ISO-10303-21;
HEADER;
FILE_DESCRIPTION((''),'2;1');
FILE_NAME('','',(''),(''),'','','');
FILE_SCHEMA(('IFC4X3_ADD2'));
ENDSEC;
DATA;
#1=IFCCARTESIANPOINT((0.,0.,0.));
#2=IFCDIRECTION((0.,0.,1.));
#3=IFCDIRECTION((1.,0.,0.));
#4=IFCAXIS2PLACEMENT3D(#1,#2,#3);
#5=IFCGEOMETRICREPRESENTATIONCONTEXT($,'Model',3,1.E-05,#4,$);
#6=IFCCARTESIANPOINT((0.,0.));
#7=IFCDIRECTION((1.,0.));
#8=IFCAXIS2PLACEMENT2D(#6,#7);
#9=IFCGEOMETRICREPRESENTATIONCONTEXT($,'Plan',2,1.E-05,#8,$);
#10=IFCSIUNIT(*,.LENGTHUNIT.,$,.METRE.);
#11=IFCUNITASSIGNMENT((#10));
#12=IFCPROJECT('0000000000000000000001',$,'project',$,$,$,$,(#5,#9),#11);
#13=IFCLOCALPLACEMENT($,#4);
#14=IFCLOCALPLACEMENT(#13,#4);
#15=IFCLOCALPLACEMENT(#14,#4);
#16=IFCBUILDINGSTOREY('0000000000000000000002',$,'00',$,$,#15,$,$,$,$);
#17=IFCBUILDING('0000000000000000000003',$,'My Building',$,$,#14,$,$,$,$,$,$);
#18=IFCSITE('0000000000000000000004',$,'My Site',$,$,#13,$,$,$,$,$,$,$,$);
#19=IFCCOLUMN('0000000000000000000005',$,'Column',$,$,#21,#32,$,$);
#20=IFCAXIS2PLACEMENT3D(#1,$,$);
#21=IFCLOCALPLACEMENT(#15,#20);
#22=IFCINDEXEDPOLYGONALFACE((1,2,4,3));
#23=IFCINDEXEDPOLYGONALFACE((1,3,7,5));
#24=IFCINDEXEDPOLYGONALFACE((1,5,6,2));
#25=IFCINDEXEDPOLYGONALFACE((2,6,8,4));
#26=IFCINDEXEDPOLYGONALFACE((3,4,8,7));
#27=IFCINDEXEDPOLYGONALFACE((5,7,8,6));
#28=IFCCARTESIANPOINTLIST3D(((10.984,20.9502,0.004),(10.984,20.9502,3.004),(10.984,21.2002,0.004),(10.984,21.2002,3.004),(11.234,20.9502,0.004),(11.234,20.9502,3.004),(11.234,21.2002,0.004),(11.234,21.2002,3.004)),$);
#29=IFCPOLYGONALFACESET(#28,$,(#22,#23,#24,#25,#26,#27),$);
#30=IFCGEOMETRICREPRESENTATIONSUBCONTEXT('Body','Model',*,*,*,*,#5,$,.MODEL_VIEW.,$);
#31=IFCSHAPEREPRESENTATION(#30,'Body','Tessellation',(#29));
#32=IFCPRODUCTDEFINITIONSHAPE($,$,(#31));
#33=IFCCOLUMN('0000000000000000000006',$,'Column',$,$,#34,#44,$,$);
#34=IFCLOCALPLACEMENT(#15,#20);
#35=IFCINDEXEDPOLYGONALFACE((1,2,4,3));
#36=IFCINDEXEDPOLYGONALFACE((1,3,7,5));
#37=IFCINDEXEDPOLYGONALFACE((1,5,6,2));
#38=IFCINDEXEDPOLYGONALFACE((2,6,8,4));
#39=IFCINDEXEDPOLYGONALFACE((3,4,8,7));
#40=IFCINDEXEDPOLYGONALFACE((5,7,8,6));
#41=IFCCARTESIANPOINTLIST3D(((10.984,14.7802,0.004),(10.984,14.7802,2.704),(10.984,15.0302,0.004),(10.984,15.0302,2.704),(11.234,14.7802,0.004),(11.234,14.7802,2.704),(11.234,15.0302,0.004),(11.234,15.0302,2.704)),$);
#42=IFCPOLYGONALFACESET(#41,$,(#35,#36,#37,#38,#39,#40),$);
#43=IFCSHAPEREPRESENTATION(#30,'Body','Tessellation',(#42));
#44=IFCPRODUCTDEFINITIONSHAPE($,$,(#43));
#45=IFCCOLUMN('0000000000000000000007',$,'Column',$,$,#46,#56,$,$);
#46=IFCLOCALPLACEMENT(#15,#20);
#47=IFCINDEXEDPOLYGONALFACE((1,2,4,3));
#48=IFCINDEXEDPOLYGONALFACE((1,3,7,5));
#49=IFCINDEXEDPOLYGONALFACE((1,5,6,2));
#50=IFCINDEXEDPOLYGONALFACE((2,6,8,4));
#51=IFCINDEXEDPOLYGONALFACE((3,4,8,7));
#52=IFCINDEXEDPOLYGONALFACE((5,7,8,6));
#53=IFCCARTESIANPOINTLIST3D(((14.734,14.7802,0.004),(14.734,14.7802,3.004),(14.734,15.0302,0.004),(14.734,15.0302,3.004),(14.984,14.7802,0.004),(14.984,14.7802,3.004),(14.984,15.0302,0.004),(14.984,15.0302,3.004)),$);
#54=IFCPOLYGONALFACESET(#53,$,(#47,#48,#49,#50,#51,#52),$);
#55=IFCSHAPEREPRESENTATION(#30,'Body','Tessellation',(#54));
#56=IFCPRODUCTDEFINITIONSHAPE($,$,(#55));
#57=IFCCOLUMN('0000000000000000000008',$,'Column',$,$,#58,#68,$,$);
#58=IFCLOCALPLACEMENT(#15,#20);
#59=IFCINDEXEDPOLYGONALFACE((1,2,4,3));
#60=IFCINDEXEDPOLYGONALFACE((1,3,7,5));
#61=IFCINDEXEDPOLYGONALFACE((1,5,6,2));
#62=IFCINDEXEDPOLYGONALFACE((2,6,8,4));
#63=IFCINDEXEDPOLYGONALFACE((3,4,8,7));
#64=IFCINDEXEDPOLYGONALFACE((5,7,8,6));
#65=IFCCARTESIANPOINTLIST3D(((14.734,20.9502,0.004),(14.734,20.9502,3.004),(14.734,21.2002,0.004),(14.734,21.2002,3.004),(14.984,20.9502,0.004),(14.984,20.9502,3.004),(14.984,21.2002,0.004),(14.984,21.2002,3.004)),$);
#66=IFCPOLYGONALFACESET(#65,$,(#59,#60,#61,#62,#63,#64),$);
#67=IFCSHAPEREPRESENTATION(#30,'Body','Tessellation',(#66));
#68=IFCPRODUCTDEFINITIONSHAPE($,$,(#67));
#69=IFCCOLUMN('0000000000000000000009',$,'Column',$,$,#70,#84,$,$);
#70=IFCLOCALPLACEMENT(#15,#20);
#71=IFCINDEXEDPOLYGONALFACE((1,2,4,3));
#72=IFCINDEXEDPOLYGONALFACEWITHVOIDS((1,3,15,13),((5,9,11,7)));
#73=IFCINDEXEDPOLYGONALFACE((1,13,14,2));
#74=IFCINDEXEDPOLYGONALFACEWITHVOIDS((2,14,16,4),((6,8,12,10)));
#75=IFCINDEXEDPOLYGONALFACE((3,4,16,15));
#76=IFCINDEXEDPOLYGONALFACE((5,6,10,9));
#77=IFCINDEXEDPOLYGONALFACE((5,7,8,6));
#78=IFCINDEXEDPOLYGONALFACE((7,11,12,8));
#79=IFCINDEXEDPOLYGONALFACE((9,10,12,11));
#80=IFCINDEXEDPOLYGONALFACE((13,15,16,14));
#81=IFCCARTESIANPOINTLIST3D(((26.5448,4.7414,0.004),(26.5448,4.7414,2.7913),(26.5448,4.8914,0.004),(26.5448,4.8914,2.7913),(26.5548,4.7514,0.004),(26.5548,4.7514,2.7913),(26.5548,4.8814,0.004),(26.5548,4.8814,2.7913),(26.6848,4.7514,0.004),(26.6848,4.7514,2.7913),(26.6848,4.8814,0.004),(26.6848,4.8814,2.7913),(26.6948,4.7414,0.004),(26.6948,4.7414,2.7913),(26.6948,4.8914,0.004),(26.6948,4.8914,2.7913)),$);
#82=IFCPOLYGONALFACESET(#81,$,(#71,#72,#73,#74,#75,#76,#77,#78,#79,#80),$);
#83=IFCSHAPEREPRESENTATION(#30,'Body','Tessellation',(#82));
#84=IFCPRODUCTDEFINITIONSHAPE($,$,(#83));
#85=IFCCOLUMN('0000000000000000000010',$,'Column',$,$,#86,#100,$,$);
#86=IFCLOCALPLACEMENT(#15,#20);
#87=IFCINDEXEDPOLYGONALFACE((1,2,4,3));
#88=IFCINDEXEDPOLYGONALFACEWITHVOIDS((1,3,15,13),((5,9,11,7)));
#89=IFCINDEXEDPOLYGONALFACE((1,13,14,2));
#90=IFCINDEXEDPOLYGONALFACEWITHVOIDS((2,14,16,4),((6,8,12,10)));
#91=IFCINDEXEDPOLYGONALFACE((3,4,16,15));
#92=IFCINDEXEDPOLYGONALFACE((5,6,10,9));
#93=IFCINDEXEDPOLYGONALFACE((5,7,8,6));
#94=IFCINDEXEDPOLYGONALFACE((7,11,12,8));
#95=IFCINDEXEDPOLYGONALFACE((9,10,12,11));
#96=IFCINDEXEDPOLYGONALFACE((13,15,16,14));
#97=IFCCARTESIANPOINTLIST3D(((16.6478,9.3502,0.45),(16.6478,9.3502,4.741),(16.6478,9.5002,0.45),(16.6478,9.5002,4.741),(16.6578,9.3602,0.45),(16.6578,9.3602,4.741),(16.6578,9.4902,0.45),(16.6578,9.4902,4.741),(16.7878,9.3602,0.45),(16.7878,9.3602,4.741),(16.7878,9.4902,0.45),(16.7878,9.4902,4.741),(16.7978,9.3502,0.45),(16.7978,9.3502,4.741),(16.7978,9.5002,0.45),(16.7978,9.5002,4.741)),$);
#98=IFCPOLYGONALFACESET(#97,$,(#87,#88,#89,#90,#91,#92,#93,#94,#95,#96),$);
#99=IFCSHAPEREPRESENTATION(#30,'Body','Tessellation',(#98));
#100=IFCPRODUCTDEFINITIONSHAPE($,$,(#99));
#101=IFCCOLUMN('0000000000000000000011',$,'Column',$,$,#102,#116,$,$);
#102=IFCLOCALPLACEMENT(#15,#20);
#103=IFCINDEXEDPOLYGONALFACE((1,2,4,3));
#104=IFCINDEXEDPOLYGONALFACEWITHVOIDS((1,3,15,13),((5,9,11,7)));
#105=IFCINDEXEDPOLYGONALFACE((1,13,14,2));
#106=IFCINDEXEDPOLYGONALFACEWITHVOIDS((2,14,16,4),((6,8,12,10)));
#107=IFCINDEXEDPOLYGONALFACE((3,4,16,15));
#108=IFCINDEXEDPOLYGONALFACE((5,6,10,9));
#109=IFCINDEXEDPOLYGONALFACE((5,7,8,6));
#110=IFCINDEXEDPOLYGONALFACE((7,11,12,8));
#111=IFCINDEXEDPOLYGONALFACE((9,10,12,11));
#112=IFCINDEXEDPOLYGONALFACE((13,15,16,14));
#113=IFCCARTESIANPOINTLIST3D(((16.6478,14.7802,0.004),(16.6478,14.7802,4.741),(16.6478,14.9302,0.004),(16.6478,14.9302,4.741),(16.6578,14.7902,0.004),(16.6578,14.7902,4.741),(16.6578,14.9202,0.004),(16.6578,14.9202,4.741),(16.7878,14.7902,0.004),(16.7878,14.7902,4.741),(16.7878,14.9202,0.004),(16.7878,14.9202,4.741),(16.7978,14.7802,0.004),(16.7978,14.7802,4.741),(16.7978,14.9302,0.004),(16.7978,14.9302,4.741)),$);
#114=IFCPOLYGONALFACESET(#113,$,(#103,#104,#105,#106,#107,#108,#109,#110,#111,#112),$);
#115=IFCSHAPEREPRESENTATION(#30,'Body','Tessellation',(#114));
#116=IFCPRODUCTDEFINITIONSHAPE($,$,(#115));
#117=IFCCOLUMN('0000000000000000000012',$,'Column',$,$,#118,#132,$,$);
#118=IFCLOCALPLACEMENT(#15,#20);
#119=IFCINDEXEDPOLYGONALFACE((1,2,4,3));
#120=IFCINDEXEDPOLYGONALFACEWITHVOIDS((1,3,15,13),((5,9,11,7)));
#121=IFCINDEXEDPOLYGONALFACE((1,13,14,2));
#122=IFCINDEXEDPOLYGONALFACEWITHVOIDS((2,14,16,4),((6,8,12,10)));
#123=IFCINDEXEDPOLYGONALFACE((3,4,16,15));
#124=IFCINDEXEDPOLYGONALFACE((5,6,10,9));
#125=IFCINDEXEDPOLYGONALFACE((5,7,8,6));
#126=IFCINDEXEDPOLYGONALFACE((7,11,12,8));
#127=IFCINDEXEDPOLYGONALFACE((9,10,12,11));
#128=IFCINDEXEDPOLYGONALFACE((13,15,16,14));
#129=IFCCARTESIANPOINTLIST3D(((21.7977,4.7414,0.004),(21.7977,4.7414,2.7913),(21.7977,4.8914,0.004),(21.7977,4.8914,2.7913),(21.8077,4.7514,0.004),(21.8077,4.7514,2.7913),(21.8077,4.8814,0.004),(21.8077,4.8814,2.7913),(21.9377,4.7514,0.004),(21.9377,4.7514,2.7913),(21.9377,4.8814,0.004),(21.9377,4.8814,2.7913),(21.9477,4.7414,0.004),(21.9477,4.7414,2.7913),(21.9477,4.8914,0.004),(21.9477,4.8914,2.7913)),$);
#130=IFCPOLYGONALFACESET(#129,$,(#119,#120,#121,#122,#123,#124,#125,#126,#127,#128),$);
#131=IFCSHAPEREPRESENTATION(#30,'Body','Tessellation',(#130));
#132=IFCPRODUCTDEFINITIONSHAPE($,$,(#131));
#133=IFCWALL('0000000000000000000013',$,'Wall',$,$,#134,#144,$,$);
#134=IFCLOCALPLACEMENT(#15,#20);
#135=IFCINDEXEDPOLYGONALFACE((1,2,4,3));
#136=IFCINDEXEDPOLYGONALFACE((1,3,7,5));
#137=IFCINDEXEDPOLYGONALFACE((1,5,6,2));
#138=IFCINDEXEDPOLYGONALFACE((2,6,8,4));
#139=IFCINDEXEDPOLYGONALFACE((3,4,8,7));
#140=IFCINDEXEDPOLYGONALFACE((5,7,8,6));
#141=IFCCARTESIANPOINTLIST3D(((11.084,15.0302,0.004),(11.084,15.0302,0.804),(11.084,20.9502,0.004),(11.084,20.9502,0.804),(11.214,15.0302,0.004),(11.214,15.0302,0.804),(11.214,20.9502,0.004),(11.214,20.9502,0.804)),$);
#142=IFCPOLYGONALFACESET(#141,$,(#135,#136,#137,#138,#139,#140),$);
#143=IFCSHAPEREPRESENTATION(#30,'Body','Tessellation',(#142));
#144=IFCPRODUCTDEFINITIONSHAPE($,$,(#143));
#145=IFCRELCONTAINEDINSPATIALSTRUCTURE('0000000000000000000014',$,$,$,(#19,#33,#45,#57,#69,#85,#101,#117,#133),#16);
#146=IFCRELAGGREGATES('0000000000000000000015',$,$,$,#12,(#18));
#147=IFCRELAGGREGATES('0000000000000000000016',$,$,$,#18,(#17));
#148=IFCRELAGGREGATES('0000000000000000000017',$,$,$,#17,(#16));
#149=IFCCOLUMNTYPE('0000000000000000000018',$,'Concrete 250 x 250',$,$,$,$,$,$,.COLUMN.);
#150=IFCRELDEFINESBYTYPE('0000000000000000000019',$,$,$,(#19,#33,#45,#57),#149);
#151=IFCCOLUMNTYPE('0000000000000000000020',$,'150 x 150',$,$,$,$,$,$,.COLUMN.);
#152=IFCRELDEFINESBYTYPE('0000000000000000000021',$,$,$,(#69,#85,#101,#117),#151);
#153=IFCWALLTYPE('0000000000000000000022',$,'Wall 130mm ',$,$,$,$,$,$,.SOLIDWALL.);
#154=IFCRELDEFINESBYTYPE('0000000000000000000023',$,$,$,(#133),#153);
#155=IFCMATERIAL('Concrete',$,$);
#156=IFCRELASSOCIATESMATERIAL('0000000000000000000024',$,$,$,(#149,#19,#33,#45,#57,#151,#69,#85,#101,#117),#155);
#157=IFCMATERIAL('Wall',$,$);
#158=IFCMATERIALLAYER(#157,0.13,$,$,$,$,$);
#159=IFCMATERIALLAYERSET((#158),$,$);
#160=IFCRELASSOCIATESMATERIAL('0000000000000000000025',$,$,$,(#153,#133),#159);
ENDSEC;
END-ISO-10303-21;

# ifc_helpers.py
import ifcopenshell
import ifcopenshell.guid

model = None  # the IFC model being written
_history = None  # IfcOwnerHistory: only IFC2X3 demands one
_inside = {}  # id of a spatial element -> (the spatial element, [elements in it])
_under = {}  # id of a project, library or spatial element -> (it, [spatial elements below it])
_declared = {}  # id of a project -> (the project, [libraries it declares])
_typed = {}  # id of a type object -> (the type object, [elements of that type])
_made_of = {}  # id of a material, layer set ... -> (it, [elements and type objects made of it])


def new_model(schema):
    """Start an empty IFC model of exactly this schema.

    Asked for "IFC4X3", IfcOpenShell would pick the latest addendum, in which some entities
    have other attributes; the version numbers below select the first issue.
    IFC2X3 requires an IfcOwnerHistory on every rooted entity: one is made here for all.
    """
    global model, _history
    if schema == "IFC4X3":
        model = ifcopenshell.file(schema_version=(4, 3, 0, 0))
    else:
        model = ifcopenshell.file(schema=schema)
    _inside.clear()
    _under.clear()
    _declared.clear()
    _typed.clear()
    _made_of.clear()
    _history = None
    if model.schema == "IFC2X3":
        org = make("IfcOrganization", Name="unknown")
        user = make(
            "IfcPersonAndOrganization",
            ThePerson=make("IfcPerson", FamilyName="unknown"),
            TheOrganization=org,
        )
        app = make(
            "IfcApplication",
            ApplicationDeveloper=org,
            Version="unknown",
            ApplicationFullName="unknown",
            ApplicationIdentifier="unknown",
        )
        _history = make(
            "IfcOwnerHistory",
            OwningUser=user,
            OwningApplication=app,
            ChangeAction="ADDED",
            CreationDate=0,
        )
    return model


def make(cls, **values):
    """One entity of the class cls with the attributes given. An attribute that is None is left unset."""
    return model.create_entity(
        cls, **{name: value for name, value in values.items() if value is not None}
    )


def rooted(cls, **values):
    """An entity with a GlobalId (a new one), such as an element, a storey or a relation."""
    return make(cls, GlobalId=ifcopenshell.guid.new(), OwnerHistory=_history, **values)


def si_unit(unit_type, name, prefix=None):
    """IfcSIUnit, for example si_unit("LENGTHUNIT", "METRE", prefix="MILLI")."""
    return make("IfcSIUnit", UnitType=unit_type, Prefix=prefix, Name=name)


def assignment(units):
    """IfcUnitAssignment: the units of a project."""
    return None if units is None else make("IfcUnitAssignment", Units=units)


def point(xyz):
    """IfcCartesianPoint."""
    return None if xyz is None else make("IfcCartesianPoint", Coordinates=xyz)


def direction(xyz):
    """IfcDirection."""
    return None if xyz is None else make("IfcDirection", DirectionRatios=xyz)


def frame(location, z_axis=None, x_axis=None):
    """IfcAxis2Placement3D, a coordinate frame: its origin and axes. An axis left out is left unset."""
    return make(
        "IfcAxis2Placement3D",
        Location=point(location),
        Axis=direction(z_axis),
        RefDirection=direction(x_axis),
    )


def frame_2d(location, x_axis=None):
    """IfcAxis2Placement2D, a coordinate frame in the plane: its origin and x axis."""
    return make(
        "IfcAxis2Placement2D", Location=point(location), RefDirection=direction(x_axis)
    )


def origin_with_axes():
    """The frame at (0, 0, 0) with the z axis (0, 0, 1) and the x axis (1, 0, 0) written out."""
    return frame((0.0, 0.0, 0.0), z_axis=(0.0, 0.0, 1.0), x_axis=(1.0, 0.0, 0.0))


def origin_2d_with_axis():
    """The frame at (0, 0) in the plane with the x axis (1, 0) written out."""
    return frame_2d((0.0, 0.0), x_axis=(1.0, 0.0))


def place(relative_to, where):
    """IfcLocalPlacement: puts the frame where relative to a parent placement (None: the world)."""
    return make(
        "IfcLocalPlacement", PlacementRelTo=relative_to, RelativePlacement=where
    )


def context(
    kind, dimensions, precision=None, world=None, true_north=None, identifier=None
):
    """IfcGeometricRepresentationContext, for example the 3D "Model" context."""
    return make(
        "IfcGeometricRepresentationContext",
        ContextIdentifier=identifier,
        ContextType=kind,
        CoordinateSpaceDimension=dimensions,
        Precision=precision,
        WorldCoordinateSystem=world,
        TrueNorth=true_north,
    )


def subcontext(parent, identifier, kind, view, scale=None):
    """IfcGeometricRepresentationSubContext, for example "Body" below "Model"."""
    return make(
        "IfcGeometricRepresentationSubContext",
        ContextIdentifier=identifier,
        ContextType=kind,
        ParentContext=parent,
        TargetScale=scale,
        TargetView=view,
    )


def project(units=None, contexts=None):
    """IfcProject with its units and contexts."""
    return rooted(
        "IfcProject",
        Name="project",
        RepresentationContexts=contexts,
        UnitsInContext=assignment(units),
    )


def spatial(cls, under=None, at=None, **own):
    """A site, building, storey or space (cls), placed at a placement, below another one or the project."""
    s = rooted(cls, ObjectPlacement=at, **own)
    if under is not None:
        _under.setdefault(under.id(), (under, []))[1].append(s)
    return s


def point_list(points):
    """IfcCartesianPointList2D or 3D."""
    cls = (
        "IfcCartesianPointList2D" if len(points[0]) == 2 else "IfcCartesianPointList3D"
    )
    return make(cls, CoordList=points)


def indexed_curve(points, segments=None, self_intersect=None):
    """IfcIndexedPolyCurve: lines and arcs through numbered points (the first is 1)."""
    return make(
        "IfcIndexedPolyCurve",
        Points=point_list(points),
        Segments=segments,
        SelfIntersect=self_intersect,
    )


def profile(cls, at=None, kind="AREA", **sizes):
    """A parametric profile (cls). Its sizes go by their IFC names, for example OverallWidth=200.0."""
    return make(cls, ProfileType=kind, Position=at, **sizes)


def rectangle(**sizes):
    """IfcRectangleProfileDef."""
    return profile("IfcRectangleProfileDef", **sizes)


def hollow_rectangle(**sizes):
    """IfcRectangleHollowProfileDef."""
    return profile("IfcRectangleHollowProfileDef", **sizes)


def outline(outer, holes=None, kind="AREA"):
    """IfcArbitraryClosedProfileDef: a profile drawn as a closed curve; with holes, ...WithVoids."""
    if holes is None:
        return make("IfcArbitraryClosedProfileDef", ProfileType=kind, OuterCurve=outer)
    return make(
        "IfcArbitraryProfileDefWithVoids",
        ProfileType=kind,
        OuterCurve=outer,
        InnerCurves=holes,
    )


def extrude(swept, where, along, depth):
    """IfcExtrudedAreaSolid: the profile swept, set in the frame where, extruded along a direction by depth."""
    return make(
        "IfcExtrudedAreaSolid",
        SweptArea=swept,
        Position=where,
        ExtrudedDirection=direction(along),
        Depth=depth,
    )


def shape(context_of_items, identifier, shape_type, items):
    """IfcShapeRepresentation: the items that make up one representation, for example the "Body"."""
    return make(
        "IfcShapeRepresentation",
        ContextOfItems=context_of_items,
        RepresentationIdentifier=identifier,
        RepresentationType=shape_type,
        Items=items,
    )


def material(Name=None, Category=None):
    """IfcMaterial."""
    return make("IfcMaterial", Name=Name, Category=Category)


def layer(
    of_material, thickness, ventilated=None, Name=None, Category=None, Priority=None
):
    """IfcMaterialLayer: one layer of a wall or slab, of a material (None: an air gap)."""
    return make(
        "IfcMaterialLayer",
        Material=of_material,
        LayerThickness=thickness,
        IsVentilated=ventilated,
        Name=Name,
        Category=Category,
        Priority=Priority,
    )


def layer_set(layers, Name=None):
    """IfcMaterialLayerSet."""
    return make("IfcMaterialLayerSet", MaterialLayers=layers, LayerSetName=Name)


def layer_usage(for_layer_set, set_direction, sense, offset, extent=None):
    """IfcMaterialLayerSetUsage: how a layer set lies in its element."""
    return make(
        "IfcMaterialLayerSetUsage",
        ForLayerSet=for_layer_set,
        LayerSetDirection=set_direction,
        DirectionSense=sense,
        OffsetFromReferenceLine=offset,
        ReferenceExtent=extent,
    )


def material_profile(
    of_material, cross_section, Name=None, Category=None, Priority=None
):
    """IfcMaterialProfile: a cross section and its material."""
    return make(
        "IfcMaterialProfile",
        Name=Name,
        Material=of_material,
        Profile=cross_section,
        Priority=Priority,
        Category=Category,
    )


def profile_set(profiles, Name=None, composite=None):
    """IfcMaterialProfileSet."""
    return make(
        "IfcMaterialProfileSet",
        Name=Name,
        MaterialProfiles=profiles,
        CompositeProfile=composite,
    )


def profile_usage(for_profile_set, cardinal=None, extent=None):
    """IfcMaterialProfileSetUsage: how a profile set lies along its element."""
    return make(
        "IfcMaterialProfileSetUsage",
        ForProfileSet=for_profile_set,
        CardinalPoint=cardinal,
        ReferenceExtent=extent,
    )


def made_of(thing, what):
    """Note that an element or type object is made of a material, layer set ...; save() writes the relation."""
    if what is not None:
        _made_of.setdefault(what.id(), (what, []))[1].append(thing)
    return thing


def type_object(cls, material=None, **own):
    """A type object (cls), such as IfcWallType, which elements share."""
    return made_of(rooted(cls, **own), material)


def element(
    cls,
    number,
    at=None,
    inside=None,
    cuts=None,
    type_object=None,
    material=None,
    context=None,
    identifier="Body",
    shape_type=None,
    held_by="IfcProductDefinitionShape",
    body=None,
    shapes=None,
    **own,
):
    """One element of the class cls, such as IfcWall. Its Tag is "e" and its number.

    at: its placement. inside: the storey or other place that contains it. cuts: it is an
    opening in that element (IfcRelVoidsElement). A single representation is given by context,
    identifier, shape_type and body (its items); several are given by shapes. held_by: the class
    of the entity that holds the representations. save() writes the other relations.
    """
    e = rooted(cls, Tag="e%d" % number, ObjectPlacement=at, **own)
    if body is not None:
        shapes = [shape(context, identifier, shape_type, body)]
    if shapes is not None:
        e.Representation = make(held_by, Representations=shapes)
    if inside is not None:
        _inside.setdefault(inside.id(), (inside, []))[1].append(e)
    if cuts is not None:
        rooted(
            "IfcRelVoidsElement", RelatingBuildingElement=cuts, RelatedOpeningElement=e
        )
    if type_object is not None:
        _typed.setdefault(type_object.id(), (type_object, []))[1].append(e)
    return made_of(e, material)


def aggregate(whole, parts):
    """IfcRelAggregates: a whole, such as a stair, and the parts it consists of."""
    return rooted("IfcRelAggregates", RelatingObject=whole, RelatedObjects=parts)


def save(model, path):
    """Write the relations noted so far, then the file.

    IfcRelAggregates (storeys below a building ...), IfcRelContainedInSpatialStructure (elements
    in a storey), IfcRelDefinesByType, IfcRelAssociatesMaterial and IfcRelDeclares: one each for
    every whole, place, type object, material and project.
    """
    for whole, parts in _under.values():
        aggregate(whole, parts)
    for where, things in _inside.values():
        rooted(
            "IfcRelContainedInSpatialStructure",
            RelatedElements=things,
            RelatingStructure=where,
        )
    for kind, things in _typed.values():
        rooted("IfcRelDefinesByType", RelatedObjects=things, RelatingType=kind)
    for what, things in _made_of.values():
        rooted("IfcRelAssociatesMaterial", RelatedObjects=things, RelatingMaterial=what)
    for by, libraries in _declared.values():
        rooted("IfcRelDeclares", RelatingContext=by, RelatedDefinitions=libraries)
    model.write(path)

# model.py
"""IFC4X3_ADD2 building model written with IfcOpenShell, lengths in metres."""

from ifc_helpers import new_model, si_unit, frame, origin_with_axes, origin_2d_with_axis, place, context, subcontext, project, spatial, indexed_curve, rectangle, hollow_rectangle, outline, extrude, material, layer, layer_set, layer_usage, material_profile, profile_set, profile_usage, type_object, element, save


model = new_model("IFC4X3_ADD2")

# Units and contexts
model_context = context("Model", 3, precision=1e-05, world=origin_with_axes())
plan_context = context("Plan", 2, precision=1e-05, world=origin_2d_with_axis())
body_context = subcontext(model_context, "Body", "Model", "MODEL_VIEW")
ifc_project = project(units=[si_unit("LENGTHUNIT", "METRE")], contexts=[model_context, plan_context])

# Site, building, storey
site_placement = place(None, origin_with_axes())
site = spatial("IfcSite", under=ifc_project, at=site_placement, Name="My Site")
building_placement = place(site_placement, origin_with_axes())
building = spatial("IfcBuilding", under=site, at=building_placement, Name="My Building")
storey_placement = place(building_placement, origin_with_axes())
storey = spatial("IfcBuildingStorey", under=building, at=storey_placement, Name="00")

# Columns
ifc_material_1 = material(Name="Concrete")
ifc_material_profile_1 = material_profile(ifc_material_1, rectangle(XDim=0.25, YDim=0.25))
ifc_profile_set_1 = profile_set([ifc_material_profile_1])
ifc_profile_usage_1 = profile_usage(ifc_profile_set_1, cardinal=5)
column_type_1 = type_object("IfcColumnType", Name="Concrete 250 x 250", PredefinedType="COLUMN", material=ifc_profile_set_1)
column_1_placement = place(storey_placement, frame((11.109, 21.0752, 0.004), z_axis=(0.0, 0.0, 1.0), x_axis=(1.0, 0.0, 0.0)))
element("IfcColumn", 1, at=column_1_placement, inside=storey, type_object=column_type_1, material=ifc_profile_usage_1, Name="Column", context=body_context, shape_type="SweptSolid", body=[
    extrude(rectangle(XDim=0.25, YDim=0.25), origin_with_axes(), (0.0, 0.0, 1.0), 3.0),
])
ifc_profile_usage_2 = profile_usage(ifc_profile_set_1, cardinal=5)
column_2_placement = place(storey_placement, frame((11.109, 14.9052, 0.004), z_axis=(0.0, 0.0, 1.0), x_axis=(1.0, 0.0, 0.0)))
element("IfcColumn", 2, at=column_2_placement, inside=storey, type_object=column_type_1, material=ifc_profile_usage_2, Name="Column", context=body_context, shape_type="SweptSolid", body=[
    extrude(rectangle(XDim=0.25, YDim=0.25), origin_with_axes(), (0.0, 0.0, 1.0), 2.7),
])
ifc_profile_usage_3 = profile_usage(ifc_profile_set_1, cardinal=5)
column_3_placement = place(storey_placement, frame((14.859, 14.9052, 0.004), z_axis=(0.0, 0.0, 1.0), x_axis=(1.0, 0.0, 0.0)))
element("IfcColumn", 3, at=column_3_placement, inside=storey, type_object=column_type_1, material=ifc_profile_usage_3, Name="Column", context=body_context, shape_type="SweptSolid", body=[
    extrude(rectangle(XDim=0.25, YDim=0.25), origin_with_axes(), (0.0, 0.0, 1.0), 3.0),
])
ifc_profile_usage_4 = profile_usage(ifc_profile_set_1, cardinal=5)
column_4_placement = place(storey_placement, frame((14.859, 21.0752, 0.004), z_axis=(0.0, 0.0, 1.0), x_axis=(1.0, 0.0, 0.0)))
element("IfcColumn", 4, at=column_4_placement, inside=storey, type_object=column_type_1, material=ifc_profile_usage_4, Name="Column", context=body_context, shape_type="SweptSolid", body=[
    extrude(rectangle(XDim=0.25, YDim=0.25), origin_with_axes(), (0.0, 0.0, 1.0), 3.0),
])
ifc_material_profile_2 = material_profile(ifc_material_1, hollow_rectangle(XDim=0.15, YDim=0.15, WallThickness=0.01))
ifc_profile_set_2 = profile_set([ifc_material_profile_2])
ifc_profile_usage_5 = profile_usage(ifc_profile_set_2, cardinal=5)
column_type_2 = type_object("IfcColumnType", Name="150 x 150", PredefinedType="COLUMN", material=ifc_profile_set_2)
column_5_placement = place(storey_placement, frame((26.6198, 4.8164, 0.004), z_axis=(0.0, 0.0, 1.0), x_axis=(1.0, 0.0, 0.0)))
element("IfcColumn", 5, at=column_5_placement, inside=storey, type_object=column_type_2, material=ifc_profile_usage_5, Name="Column", context=body_context, shape_type="SweptSolid", body=[
    extrude(hollow_rectangle(XDim=0.15, YDim=0.15, WallThickness=0.01), origin_with_axes(), (0.0, 0.0, 1.0), 2.7873),
])
ifc_profile_usage_6 = profile_usage(ifc_profile_set_2, cardinal=5)
column_6_placement = place(storey_placement, frame((16.7228, 9.4252, 0.45), z_axis=(0.0, 0.0, 1.0), x_axis=(1.0, 0.0, 0.0)))
element("IfcColumn", 6, at=column_6_placement, inside=storey, type_object=column_type_2, material=ifc_profile_usage_6, Name="Column", context=body_context, shape_type="SweptSolid", body=[
    extrude(hollow_rectangle(XDim=0.15, YDim=0.15, WallThickness=0.01), origin_with_axes(), (0.0, 0.0, 1.0), 4.291),
])
ifc_profile_usage_7 = profile_usage(ifc_profile_set_2, cardinal=5)
column_7_placement = place(storey_placement, frame((16.7228, 14.8552, 0.004), z_axis=(0.0, 0.0, 1.0), x_axis=(1.0, 0.0, 0.0)))
element("IfcColumn", 7, at=column_7_placement, inside=storey, type_object=column_type_2, material=ifc_profile_usage_7, Name="Column", context=body_context, shape_type="SweptSolid", body=[
    extrude(hollow_rectangle(XDim=0.15, YDim=0.15, WallThickness=0.01), origin_with_axes(), (0.0, 0.0, 1.0), 4.737),
])
ifc_profile_usage_8 = profile_usage(ifc_profile_set_2, cardinal=5)
column_8_placement = place(storey_placement, frame((21.8727, 4.8164, 0.004), z_axis=(0.0, 0.0, 1.0), x_axis=(1.0, 0.0, 0.0)))
element("IfcColumn", 8, at=column_8_placement, inside=storey, type_object=column_type_2, material=ifc_profile_usage_8, Name="Column", context=body_context, shape_type="SweptSolid", body=[
    extrude(hollow_rectangle(XDim=0.15, YDim=0.15, WallThickness=0.01), origin_with_axes(), (0.0, 0.0, 1.0), 2.7873),
])

# Wall
ifc_material_2 = material(Name="Wall")
ifc_layer_1 = layer(ifc_material_2, 0.13)
ifc_layer_set_1 = layer_set([ifc_layer_1])
ifc_layer_usage_1 = layer_usage(ifc_layer_set_1, "AXIS2", "POSITIVE", 0.0)
wall_type_1 = type_object("IfcWallType", Name="Wall 130mm ", PredefinedType="SOLIDWALL", material=ifc_layer_set_1)
wall_1_placement = place(storey_placement, frame((11.214, 15.0302, 0.004), z_axis=(0.0, 0.0, 1.0), x_axis=(0.000001, 1.0, 0.0)))
element("IfcWall", 9, at=wall_1_placement, inside=storey, type_object=wall_type_1, material=ifc_layer_usage_1, Name="Wall", context=body_context, shape_type="SweptSolid", body=[
    extrude(outline(indexed_curve([(0.0, 0.0), (0.0, 0.13), (5.92, 0.13), (5.92, 0.0), (0.0, 0.0)], self_intersect=False)), origin_with_axes(), (0.0, 0.0, 1.0), 0.8),
])

save(model, "model.ifc")
